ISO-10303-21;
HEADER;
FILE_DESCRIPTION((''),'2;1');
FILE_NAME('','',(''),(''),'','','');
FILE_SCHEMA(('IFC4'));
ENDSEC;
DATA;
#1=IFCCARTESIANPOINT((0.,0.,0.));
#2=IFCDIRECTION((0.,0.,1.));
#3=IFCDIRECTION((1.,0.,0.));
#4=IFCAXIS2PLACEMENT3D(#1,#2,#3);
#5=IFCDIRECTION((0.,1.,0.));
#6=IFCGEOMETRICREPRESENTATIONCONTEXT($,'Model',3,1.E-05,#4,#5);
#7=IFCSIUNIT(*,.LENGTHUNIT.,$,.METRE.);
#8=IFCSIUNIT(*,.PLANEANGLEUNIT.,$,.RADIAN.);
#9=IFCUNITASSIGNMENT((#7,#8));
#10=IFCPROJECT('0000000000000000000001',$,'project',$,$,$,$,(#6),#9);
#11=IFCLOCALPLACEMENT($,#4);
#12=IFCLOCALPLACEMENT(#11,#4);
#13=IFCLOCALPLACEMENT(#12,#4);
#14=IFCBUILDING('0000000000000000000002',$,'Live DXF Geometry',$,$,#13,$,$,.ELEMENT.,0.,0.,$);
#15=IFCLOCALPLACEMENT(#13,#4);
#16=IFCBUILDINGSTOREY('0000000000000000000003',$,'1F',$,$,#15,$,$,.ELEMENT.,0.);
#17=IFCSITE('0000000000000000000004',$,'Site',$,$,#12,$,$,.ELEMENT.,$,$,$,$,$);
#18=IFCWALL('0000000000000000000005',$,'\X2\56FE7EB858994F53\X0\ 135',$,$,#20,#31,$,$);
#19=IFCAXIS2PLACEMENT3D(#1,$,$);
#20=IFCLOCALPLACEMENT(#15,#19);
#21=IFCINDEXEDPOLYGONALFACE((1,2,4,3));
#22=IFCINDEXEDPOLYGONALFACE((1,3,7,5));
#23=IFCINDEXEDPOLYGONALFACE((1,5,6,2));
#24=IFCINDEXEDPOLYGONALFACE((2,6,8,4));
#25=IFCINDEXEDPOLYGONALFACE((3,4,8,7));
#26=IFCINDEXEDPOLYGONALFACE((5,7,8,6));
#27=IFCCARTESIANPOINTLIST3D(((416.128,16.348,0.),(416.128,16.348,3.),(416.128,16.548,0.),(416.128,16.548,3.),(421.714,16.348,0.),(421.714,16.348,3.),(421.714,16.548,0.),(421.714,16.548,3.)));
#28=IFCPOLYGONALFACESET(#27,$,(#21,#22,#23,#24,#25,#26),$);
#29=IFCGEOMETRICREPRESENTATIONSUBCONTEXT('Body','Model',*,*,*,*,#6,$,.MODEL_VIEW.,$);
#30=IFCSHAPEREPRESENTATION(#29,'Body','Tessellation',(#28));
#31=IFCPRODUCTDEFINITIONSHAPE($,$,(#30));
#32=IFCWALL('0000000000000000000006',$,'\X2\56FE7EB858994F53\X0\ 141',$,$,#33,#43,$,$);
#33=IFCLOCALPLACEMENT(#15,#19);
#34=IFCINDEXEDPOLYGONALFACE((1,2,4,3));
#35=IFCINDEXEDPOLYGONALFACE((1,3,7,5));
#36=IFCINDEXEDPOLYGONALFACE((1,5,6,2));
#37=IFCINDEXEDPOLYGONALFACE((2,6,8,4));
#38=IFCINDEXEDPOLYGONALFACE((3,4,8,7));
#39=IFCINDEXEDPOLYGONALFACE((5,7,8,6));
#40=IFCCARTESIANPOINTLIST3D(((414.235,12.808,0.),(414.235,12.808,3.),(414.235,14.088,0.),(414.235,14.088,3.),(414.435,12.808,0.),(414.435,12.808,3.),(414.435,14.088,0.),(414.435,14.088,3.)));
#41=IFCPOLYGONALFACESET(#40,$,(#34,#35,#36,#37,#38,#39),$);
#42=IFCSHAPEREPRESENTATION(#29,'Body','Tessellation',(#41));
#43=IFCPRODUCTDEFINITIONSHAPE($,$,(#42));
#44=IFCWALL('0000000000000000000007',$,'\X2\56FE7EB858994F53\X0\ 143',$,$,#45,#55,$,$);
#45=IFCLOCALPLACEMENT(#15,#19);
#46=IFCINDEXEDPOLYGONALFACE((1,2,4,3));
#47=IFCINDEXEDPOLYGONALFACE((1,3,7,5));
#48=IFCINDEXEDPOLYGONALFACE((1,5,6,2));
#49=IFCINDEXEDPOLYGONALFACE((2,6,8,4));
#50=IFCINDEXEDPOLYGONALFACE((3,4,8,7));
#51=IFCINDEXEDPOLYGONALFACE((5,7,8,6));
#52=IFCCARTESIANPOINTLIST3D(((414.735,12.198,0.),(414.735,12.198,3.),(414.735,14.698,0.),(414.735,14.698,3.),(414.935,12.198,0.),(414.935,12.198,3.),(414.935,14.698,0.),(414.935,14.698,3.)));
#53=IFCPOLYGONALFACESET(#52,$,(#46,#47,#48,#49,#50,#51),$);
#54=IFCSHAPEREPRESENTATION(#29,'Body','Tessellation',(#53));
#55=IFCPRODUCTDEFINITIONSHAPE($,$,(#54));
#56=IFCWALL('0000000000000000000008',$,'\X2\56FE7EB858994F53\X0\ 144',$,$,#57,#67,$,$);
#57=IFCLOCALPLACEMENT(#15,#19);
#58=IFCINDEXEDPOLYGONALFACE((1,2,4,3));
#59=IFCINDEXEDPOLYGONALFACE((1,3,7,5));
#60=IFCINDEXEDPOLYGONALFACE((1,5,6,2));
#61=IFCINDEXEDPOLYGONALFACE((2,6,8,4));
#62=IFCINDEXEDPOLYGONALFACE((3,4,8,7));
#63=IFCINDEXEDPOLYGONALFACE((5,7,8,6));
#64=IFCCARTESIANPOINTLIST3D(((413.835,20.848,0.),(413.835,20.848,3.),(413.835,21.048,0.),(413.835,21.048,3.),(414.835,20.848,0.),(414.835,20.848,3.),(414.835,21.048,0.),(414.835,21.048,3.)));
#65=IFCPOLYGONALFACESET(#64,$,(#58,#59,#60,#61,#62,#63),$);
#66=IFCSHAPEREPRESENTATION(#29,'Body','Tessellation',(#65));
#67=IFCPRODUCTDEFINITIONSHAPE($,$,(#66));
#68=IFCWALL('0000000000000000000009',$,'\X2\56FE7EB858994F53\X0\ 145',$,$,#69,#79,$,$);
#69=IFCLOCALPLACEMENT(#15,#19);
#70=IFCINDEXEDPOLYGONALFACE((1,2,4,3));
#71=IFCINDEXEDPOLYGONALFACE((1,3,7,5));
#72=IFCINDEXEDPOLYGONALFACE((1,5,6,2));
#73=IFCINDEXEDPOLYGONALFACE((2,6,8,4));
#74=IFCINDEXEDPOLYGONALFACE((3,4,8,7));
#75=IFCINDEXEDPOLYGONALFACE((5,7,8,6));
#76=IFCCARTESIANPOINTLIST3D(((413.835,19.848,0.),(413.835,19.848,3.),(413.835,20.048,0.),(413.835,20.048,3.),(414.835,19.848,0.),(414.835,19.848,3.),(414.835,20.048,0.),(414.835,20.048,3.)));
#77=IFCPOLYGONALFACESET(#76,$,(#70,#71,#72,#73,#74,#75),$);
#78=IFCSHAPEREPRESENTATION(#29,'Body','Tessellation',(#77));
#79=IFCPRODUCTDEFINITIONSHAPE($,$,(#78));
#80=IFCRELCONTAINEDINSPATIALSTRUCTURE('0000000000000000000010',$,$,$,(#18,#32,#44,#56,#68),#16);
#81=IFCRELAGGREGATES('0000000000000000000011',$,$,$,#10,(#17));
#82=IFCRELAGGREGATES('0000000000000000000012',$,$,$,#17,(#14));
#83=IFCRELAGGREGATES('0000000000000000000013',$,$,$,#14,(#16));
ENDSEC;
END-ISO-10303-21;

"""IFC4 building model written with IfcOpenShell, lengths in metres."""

from ifc_helpers import new_model, si_unit, direction, frame, frame_2d, origin_with_axes, place, context, subcontext, project, spatial, rectangle, extrude, element, save


model = new_model("IFC4")

# Units and contexts
model_context = context("Model", 3, precision=1e-05, world=origin_with_axes(), true_north=direction((0.0, 1.0, 0.0)))
body_context = subcontext(model_context, "Body", "Model", "MODEL_VIEW")
ifc_project = project(units=[si_unit("LENGTHUNIT", "METRE"), si_unit("PLANEANGLEUNIT", "RADIAN")], contexts=[model_context])

# Site, building, storey
placement = place(None, origin_with_axes())
site_placement = place(placement, origin_with_axes())
site = spatial("IfcSite", under=ifc_project, at=site_placement, Name="Site", CompositionType="ELEMENT")
building_placement = place(site_placement, origin_with_axes())
building = spatial("IfcBuilding", under=site, at=building_placement, Name="Live DXF Geometry", CompositionType="ELEMENT", ElevationOfRefHeight=0.0, ElevationOfTerrain=0.0)
storey_placement = place(building_placement, origin_with_axes())
storey = spatial("IfcBuildingStorey", under=building, at=storey_placement, Name="1F", CompositionType="ELEMENT", Elevation=0.0)

# Walls
wall_1_placement = place(storey_placement, frame((418.921, 16.448, 0.0), z_axis=(0.0, 0.0, 1.0), x_axis=(-1.0, 0.0, 0.0)))
element("IfcWall", 1, at=wall_1_placement, inside=storey, Name="图纸墙体 135", context=body_context, shape_type="SweptSolid", body=[
    extrude(rectangle(XDim=5.586, YDim=0.2, at=frame_2d((0.0, 0.0), x_axis=(1.0, 0.0, 0.0))), frame((0.0, 0.0, 0.0), z_axis=(0.0, 0.0, 1.0)), (0.0, 0.0, 1.0), 3.0),
])
wall_2_placement = place(storey_placement, frame((414.335, 13.448, 0.0), z_axis=(0.0, 0.0, 1.0), x_axis=(0.0, -1.0, 0.0)))
element("IfcWall", 2, at=wall_2_placement, inside=storey, Name="图纸墙体 141", context=body_context, shape_type="SweptSolid", body=[
    extrude(rectangle(XDim=1.28, YDim=0.2, at=frame_2d((0.0, 0.0), x_axis=(1.0, 0.0, 0.0))), frame((0.0, 0.0, 0.0), z_axis=(0.0, 0.0, 1.0)), (0.0, 0.0, 1.0), 3.0),
])
wall_3_placement = place(storey_placement, frame((414.835, 13.448, 0.0), z_axis=(0.0, 0.0, 1.0), x_axis=(0.0, 1.0, 0.0)))
element("IfcWall", 3, at=wall_3_placement, inside=storey, Name="图纸墙体 143", context=body_context, shape_type="SweptSolid", body=[
    extrude(rectangle(XDim=2.5, YDim=0.2, at=frame_2d((0.0, 0.0), x_axis=(1.0, 0.0, 0.0))), frame((0.0, 0.0, 0.0), z_axis=(0.0, 0.0, 1.0)), (0.0, 0.0, 1.0), 3.0),
])
for number, where, z_axis, x_axis, name in (
    (4, (414.335, 20.948, 0.0), (0.0, 0.0, 1.0), (-1.0, 0.0, 0.0), "图纸墙体 144"),
    (5, (414.335, 19.948, 0.0), (0.0, 0.0, 1.0), (-1.0, 0.0, 0.0), "图纸墙体 145"),
):
    element("IfcWall", number, at=place(storey_placement, frame(where, z_axis=z_axis, x_axis=x_axis)), inside=storey, Name=name, context=body_context, shape_type="SweptSolid", body=[
        extrude(rectangle(XDim=1.0, YDim=0.2, at=frame_2d((0.0, 0.0), x_axis=(1.0, 0.0, 0.0))), frame((0.0, 0.0, 0.0), z_axis=(0.0, 0.0, 1.0)), (0.0, 0.0, 1.0), 3.0),
    ])

save(model, "model.ifc")
